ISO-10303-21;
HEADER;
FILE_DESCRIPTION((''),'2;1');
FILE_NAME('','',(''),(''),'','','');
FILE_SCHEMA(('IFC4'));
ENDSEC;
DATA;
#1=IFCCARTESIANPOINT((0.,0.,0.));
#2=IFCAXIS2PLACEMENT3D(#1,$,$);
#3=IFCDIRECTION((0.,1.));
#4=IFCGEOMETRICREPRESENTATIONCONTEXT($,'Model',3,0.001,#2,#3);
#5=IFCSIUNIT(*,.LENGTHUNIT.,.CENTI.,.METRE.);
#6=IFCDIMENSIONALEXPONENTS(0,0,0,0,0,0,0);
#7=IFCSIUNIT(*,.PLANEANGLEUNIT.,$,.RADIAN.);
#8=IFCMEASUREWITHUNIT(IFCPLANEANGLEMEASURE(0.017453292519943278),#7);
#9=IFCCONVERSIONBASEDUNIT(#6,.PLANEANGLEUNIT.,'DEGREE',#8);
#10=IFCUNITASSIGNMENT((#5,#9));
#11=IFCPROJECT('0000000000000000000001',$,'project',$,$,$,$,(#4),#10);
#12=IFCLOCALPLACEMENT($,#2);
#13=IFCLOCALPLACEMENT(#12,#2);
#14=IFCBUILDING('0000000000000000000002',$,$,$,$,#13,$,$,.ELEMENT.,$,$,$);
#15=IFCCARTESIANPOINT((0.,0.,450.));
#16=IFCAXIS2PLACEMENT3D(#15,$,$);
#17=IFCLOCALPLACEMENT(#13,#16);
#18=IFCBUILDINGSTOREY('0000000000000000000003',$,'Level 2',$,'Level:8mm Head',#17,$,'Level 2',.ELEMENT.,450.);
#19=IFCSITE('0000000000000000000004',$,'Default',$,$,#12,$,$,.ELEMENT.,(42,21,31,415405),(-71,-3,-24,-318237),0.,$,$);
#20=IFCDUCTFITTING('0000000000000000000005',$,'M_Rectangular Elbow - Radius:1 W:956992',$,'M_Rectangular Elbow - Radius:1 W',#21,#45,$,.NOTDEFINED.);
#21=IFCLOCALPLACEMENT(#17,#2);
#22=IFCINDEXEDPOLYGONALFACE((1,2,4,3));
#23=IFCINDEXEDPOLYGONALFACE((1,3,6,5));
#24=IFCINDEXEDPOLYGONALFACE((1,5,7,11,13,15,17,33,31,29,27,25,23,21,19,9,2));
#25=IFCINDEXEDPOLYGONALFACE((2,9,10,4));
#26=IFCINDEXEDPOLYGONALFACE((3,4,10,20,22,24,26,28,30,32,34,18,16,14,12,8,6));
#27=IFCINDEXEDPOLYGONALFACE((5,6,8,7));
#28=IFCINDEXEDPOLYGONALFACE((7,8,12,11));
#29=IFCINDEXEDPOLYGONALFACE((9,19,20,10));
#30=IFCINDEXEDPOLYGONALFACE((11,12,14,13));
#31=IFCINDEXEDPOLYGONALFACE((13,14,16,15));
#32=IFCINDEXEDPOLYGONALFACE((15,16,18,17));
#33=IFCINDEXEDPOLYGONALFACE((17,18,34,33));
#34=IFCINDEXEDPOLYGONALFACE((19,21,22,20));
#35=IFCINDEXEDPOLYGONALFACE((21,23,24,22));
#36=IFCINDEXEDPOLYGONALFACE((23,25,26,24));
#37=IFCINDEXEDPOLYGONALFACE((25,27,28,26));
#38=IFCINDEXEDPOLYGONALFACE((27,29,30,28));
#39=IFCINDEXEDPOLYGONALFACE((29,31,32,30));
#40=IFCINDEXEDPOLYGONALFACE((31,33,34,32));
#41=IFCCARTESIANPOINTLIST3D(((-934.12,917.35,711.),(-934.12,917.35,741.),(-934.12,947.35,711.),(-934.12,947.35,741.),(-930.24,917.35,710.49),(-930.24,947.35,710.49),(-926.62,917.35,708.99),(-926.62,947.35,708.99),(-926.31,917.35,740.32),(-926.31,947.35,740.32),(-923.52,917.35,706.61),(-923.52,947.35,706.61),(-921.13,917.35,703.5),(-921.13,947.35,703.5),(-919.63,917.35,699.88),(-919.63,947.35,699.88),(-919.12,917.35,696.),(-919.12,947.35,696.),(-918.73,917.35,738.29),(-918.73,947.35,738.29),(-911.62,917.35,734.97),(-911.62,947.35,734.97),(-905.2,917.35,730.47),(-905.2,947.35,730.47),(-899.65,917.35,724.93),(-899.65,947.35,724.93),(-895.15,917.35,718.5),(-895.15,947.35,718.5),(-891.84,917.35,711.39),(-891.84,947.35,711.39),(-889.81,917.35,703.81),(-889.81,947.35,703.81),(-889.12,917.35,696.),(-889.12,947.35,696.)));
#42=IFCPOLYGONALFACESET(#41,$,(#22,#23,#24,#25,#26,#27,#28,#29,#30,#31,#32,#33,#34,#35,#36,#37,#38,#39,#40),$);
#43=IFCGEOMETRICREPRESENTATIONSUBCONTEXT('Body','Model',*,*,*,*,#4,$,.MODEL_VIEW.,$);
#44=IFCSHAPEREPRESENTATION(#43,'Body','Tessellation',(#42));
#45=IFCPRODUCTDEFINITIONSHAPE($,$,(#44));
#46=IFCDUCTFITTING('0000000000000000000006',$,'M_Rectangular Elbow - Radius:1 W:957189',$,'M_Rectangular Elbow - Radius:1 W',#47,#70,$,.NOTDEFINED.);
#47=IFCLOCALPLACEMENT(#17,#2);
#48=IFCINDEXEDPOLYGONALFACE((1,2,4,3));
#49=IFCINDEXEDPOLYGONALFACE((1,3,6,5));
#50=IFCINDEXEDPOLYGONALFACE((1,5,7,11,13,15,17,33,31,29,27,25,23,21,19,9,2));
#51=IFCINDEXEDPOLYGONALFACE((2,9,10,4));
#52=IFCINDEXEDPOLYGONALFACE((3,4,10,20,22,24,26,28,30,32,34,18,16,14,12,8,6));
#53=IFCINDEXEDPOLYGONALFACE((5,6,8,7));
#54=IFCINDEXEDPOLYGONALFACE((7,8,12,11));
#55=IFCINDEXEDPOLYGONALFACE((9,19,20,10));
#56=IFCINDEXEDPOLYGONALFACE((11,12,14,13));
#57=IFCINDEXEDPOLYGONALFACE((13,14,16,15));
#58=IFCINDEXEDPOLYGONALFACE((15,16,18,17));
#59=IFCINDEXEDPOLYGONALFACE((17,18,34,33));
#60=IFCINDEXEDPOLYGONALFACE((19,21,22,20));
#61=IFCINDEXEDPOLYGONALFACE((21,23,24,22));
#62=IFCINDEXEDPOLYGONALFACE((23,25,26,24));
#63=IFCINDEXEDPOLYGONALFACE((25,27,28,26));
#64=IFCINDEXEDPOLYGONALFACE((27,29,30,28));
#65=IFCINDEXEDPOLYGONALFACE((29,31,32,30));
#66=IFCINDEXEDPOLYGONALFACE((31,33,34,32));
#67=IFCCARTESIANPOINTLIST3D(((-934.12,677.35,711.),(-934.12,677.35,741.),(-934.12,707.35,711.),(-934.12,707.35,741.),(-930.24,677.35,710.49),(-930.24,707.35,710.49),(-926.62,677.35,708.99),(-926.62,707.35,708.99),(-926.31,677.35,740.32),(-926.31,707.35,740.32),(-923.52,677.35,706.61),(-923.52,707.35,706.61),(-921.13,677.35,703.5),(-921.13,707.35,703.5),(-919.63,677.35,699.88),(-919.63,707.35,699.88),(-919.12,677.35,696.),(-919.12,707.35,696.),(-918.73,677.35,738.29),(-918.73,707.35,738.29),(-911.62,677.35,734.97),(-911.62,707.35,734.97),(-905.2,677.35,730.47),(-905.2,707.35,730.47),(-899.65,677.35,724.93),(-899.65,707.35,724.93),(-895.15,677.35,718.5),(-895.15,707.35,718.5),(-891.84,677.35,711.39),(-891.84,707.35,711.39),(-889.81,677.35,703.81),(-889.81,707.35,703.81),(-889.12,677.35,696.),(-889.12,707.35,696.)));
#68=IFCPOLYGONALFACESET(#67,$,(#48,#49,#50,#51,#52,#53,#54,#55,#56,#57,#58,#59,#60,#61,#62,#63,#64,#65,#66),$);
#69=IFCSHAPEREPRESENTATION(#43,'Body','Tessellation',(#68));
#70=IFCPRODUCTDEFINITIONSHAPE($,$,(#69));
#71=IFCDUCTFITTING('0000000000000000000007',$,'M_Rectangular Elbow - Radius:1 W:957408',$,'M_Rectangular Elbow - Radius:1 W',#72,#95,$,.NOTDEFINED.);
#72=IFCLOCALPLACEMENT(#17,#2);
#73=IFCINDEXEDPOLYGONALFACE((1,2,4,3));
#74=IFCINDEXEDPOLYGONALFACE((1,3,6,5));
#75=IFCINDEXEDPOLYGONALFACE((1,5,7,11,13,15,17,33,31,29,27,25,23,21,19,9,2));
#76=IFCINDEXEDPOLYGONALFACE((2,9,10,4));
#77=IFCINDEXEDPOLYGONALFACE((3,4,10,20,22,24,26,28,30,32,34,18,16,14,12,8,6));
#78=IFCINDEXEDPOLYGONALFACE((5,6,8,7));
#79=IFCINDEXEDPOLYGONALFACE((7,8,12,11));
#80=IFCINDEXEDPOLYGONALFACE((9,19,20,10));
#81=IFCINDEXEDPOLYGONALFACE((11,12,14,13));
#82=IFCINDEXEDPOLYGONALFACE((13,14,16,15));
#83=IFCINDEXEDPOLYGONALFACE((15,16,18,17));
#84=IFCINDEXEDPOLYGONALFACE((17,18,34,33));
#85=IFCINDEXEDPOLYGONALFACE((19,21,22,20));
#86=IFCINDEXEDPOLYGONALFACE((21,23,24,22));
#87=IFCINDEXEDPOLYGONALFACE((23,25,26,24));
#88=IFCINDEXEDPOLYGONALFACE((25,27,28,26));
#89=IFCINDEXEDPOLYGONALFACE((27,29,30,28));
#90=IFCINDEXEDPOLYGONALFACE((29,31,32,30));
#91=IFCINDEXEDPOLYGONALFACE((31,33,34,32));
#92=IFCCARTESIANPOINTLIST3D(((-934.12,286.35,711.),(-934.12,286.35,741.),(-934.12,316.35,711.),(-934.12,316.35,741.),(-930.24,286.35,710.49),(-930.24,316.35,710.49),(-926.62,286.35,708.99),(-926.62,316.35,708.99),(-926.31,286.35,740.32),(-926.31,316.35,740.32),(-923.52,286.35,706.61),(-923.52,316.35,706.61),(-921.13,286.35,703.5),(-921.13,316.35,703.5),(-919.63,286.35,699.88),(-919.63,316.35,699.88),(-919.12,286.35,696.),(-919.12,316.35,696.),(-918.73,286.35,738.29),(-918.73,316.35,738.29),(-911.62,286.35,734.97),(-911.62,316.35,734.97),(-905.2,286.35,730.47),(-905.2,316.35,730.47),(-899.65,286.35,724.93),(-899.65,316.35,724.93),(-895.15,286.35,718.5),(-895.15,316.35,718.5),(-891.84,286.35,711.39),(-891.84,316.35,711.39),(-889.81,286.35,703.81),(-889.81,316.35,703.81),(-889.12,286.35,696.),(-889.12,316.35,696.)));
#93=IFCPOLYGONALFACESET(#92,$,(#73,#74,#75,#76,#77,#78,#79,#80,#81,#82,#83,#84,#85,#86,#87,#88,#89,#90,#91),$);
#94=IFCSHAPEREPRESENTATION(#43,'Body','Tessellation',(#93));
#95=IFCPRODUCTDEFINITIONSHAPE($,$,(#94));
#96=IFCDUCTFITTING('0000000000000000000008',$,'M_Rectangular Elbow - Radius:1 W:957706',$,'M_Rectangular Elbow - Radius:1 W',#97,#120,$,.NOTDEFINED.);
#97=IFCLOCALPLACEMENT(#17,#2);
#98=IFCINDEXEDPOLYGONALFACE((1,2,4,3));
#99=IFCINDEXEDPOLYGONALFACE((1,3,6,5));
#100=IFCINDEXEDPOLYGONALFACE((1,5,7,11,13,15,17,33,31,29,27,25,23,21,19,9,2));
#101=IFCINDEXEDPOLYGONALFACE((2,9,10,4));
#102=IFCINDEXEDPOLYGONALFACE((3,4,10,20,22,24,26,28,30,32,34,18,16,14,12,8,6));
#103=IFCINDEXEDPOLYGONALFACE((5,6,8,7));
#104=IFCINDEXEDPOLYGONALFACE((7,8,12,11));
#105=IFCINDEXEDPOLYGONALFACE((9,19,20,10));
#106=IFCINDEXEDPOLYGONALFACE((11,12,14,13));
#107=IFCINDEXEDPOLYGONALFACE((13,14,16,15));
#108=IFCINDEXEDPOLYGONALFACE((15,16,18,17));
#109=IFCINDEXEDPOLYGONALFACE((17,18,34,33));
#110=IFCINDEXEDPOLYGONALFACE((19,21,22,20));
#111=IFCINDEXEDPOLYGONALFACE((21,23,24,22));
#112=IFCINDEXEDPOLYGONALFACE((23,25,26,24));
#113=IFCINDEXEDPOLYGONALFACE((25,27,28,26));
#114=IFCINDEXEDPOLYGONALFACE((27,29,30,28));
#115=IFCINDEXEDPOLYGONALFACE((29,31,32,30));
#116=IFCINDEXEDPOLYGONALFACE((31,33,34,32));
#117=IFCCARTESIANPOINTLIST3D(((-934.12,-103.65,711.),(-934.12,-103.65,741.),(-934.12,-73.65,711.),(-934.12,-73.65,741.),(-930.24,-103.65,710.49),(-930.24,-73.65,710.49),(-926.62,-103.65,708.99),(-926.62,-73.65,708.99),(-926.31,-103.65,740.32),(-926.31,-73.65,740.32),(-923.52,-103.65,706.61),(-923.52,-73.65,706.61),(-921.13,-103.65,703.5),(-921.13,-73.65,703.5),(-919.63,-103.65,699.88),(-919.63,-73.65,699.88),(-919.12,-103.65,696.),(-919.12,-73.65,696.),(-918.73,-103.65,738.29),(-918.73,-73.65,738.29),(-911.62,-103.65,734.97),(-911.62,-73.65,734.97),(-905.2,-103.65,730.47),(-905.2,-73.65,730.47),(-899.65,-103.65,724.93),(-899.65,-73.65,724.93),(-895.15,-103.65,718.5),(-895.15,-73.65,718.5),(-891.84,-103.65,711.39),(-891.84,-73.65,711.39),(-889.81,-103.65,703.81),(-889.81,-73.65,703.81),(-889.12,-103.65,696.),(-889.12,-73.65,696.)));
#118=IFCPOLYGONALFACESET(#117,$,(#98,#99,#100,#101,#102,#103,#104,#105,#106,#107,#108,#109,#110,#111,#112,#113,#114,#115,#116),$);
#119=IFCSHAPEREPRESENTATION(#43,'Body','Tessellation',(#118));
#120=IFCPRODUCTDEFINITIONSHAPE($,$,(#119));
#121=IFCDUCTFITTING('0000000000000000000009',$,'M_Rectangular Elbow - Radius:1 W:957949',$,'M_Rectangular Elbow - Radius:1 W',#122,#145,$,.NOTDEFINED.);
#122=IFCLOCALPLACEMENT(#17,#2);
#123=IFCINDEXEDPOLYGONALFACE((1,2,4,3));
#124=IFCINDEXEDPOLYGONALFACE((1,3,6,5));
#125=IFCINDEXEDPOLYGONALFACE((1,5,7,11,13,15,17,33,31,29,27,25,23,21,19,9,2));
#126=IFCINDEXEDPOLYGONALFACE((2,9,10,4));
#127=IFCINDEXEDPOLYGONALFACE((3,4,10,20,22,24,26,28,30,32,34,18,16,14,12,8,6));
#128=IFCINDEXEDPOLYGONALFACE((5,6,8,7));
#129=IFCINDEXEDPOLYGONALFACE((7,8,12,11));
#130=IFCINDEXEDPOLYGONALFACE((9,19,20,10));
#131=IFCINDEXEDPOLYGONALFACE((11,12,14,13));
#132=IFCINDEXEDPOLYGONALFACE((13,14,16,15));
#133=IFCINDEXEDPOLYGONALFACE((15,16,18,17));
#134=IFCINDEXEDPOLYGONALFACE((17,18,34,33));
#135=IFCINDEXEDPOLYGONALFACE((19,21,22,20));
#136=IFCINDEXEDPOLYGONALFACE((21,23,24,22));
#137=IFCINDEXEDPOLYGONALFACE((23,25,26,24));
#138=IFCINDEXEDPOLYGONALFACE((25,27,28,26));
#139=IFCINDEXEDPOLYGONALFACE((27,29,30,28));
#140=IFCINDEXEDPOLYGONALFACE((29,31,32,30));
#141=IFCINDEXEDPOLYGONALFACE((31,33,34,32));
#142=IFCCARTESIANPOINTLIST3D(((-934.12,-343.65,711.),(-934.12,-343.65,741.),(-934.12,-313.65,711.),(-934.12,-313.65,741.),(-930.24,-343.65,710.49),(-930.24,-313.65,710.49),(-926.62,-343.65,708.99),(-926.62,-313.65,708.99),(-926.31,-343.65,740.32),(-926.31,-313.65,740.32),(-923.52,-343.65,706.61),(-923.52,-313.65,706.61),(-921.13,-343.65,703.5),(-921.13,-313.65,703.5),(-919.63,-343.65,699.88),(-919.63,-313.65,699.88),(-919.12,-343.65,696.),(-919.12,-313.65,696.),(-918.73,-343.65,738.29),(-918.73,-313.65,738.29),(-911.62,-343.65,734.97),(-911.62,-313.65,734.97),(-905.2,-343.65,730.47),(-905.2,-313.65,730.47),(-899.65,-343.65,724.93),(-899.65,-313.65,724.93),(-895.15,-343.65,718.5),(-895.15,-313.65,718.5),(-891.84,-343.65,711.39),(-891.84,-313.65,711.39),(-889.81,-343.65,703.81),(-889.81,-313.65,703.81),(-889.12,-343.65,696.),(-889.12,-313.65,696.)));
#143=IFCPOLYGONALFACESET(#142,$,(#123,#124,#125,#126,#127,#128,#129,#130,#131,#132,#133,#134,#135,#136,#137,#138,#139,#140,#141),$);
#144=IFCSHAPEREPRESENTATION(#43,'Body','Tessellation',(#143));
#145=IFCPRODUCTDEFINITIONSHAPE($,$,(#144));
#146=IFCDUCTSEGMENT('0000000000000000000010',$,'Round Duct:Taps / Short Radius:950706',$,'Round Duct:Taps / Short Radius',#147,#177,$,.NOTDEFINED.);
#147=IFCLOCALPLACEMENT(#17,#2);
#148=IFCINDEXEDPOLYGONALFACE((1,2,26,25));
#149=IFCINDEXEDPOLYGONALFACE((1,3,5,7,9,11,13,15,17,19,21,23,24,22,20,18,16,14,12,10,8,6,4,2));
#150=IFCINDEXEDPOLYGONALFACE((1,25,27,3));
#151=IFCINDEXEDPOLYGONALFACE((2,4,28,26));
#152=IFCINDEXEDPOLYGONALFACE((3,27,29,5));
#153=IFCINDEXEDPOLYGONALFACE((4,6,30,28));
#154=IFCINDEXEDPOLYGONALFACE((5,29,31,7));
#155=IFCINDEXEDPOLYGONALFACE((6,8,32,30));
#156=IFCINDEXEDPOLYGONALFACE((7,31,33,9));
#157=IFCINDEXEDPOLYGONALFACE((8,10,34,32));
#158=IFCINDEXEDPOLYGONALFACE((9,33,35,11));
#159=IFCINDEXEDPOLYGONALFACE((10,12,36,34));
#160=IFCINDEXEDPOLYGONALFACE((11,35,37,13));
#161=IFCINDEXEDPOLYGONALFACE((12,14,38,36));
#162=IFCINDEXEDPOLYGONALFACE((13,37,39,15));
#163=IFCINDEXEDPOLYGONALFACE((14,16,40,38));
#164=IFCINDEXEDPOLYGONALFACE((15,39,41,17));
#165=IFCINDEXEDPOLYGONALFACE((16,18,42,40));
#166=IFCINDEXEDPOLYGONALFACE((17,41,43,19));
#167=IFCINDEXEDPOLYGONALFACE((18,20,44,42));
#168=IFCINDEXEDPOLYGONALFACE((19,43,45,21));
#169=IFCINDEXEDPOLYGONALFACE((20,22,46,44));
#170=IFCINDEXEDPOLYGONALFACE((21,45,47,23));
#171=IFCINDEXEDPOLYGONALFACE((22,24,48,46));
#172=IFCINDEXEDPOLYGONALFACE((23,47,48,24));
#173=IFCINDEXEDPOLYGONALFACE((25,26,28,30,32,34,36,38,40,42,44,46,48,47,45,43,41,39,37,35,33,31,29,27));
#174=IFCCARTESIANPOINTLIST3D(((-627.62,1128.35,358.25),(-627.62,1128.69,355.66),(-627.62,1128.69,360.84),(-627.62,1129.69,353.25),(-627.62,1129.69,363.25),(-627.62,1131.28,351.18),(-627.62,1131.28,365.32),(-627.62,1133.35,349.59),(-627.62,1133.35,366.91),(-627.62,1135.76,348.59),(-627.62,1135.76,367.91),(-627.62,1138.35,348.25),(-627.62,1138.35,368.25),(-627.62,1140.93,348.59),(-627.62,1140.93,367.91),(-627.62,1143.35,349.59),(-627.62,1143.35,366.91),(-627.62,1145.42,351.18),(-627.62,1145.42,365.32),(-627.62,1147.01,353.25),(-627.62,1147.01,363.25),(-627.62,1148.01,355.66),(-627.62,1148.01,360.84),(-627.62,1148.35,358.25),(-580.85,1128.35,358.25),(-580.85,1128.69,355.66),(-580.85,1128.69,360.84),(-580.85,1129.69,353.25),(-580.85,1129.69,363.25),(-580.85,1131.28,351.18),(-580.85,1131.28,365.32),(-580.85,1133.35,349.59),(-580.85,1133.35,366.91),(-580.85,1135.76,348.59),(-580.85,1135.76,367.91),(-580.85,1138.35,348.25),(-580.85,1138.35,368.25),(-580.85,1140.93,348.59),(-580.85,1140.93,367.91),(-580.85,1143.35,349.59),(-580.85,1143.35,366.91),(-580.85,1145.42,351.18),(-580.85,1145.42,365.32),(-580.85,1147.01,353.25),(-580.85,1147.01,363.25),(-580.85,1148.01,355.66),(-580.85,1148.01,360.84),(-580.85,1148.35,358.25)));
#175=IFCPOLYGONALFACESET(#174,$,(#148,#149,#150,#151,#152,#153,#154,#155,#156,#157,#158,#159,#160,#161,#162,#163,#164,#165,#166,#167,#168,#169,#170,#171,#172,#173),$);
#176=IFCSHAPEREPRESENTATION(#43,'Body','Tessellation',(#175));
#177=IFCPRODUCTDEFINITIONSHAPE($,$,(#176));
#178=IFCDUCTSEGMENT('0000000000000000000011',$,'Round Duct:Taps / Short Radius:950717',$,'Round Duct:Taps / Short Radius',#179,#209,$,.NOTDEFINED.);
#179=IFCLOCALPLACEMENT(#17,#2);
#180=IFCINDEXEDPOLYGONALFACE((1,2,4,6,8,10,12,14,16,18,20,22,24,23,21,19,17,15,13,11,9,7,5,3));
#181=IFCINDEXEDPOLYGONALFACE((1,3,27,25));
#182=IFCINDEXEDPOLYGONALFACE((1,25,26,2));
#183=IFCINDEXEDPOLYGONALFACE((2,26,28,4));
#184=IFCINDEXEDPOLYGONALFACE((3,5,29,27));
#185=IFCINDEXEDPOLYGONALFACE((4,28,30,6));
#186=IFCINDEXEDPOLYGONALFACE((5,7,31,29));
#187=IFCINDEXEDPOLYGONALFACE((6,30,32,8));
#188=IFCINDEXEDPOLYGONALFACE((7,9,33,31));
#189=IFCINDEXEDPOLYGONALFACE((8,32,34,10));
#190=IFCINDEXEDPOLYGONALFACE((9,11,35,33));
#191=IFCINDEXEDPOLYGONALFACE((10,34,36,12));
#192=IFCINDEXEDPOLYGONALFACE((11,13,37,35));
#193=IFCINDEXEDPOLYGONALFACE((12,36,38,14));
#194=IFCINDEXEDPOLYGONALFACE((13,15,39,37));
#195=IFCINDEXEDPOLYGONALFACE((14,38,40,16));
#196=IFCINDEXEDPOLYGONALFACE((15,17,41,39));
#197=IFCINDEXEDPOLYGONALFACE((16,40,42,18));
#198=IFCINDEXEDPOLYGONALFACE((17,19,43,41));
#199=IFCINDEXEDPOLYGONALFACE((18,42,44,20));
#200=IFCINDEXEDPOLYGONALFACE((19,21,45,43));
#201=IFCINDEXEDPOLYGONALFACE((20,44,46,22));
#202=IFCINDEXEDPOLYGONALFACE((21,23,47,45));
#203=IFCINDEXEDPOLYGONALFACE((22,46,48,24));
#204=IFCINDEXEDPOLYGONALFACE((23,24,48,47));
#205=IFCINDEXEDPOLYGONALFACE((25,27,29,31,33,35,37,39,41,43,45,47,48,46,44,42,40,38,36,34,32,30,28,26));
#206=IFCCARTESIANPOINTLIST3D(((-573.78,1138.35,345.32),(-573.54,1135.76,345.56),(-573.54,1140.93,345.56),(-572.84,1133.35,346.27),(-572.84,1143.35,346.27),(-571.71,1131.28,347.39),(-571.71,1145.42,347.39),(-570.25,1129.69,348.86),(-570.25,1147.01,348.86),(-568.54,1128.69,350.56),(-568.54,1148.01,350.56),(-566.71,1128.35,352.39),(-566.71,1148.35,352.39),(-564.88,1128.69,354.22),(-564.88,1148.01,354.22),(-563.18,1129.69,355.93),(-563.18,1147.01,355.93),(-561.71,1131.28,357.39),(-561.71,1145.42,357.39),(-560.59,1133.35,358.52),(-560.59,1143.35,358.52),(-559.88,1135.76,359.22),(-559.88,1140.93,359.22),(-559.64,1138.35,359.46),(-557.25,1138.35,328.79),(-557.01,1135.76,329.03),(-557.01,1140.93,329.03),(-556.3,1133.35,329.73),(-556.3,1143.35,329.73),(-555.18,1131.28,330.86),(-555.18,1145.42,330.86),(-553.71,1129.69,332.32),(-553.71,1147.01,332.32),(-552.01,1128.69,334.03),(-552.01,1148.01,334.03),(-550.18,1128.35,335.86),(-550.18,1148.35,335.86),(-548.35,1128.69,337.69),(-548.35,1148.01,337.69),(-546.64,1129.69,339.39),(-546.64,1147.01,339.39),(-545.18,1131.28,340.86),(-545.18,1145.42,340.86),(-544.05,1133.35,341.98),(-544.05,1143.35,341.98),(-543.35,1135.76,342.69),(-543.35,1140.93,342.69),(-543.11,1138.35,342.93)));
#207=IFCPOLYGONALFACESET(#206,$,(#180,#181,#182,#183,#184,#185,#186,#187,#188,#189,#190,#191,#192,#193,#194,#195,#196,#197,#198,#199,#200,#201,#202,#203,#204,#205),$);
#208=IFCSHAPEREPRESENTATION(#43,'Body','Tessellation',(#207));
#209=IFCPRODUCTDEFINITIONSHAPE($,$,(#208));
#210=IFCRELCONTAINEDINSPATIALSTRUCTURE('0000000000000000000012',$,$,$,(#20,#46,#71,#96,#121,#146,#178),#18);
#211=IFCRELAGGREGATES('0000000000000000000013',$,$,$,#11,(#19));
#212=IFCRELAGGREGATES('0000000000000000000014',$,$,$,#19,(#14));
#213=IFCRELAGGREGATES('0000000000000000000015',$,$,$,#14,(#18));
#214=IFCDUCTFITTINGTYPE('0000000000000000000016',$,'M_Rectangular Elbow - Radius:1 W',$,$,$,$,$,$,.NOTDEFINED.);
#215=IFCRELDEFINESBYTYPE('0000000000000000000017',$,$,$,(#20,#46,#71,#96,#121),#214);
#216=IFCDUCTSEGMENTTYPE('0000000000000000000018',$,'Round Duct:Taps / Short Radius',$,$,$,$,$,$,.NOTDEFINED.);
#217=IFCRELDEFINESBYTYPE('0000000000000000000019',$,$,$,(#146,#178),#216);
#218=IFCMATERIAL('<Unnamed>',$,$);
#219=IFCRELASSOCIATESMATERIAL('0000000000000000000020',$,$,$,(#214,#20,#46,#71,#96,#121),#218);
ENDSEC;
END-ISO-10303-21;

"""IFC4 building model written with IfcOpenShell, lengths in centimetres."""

from ifc_helpers import new_model, entity, si_unit, converted_unit, direction, frame, origin, place, context, subcontext, project, spatial, line, arc, indexed_curve, outline, extrude, source, transform, mapped, material, type_object, type_shapes, element, save


model = new_model("IFC4")

# Units and contexts
model_context = context("Model", 3, precision=0.001, world=origin(), true_north=direction((0.0, 1.0)))
body_context = subcontext(model_context, "Body", "Model", "MODEL_VIEW")
ifc_project = project(units=[si_unit("LENGTHUNIT", "METRE", prefix="CENTI"), converted_unit("PLANEANGLEUNIT", "DEGREE", entity("IfcPlaneAngleMeasure", 0.017453292519943278), si_unit("PLANEANGLEUNIT", "RADIAN"), dimensions=[0, 0, 0, 0, 0, 0, 0])], contexts=[model_context])

# Site, building, storey
site_placement = place(None, origin())
site = spatial("IfcSite", under=ifc_project, at=site_placement, Name="Default", CompositionType="ELEMENT", RefLatitude=(42, 21, 31, 415405), RefLongitude=(-71, -3, -24, -318237), RefElevation=0.0)
building_placement = place(site_placement, origin())
building = spatial("IfcBuilding", under=site, at=building_placement, CompositionType="ELEMENT")
storey_placement = place(building_placement, frame((0.0, 0.0, 450.0)))
storey = spatial("IfcBuildingStorey", under=building, at=storey_placement, Name="Level 2", ObjectType="Level:8mm Head", LongName="Level 2", CompositionType="ELEMENT", Elevation=450.0)

# Duct fittings
ifc_material = material(Name="<Unnamed>")
duct_fitting_type_1 = type_object("IfcDuctFittingType", Name="M_Rectangular Elbow - Radius:1 W", PredefinedType="NOTDEFINED", material=ifc_material)
shared_shape_1 = source(origin(), body_context, "Body", "SweptSolid", [
    extrude(outline(indexed_curve([(-30.0, -15.0), (0.0, -15.0), (4.39, -4.39), (15.0, 0.0), (15.0, 30.0), (-16.82, 16.82)], segments=[line(1, 2), arc(2, 3, 4), line(4, 5), arc(5, 6, 1)], self_intersect=False)), frame((-15.0, 15.0, -15.0), z_axis=(0.0, 0.0, 1.0), x_axis=(-1.0, 0.0, 0.0)), (0.0, 0.0, 1.0), 30.0),
])
type_shapes(duct_fitting_type_1, [shared_shape_1])
for number, where, z_axis, x_axis, name in (
    (1, (-904.12, 932.35, 726.0), (0.0, 1.0, 0.0), (1.0, 0.0, 0.0), "M_Rectangular Elbow - Radius:1 W:956992"),
    (2, (-904.12, 692.35, 726.0), (0.0, 1.0, 0.0), (1.0, 0.0, 0.0), "M_Rectangular Elbow - Radius:1 W:957189"),
    (3, (-904.12, 301.35, 726.0), (0.0, 1.0, 0.0), (1.0, 0.0, 0.0), "M_Rectangular Elbow - Radius:1 W:957408"),
    (4, (-904.12, -88.65, 726.0), (0.0, 1.0, 0.0), (1.0, 0.0, 0.0), "M_Rectangular Elbow - Radius:1 W:957706"),
    (5, (-904.12, -328.65, 726.0), (0.0, 1.0, 0.0), (1.0, 0.0, 0.0), "M_Rectangular Elbow - Radius:1 W:957949"),
):
    element("IfcDuctFitting", number, at=place(storey_placement, frame(where, z_axis=z_axis, x_axis=x_axis)), inside=storey, type_object=duct_fitting_type_1, material=ifc_material, Name=name, ObjectType="M_Rectangular Elbow - Radius:1 W", PredefinedType="NOTDEFINED", context=body_context, shape_type="MappedRepresentation", body=[
        mapped(shared_shape_1, transform((0.0, 0.0, 0.0), scale=1.0)),
    ])

# Duct segments
duct_segment_type_1 = type_object("IfcDuctSegmentType", Name="Round Duct:Taps / Short Radius", PredefinedType="NOTDEFINED")
duct_segment_1_placement = place(storey_placement, origin())
element("IfcDuctSegment", 6, at=duct_segment_1_placement, inside=storey, type_object=duct_segment_type_1, Name="Round Duct:Taps / Short Radius:950706", ObjectType="Round Duct:Taps / Short Radius", PredefinedType="NOTDEFINED", context=body_context, shape_type="SweptSolid", body=[
    extrude(outline(indexed_curve([(10.0, 0.0), (7.07, 7.07), (0.0, 10.0), (-7.07, 7.07), (-10.0, 0.0), (-7.07, -7.07), (0.0, -10.0), (7.07, -7.07)], segments=[arc(1, 2, 3), arc(3, 4, 5), arc(5, 6, 7), arc(7, 8, 1)], self_intersect=False)), frame((-627.62, 1138.35, 358.25), z_axis=(1.0, 0.0, 0.0), x_axis=(0.0, 1.0, 0.0)), (0.0, 0.0, 1.0), 46.77),
])
duct_segment_2_placement = place(storey_placement, origin())
element("IfcDuctSegment", 7, at=duct_segment_2_placement, inside=storey, type_object=duct_segment_type_1, Name="Round Duct:Taps / Short Radius:950717", ObjectType="Round Duct:Taps / Short Radius", PredefinedType="NOTDEFINED", context=body_context, shape_type="SweptSolid", body=[
    extrude(outline(indexed_curve([(10.0, 0.0), (7.07, 7.07), (0.0, 10.0), (-7.07, 7.07), (-10.0, 0.0), (-7.07, -7.07), (0.0, -10.0), (7.07, -7.07)], segments=[arc(1, 2, 3), arc(3, 4, 5), arc(5, 6, 7), arc(7, 8, 1)], self_intersect=False)), frame((-550.18, 1138.35, 335.86), z_axis=(-0.707107, 0.0, 0.707107), x_axis=(0.0, 1.0, 0.0)), (0.0, 0.0, 1.0), 23.38),
])

save(model, "model.ifc")
